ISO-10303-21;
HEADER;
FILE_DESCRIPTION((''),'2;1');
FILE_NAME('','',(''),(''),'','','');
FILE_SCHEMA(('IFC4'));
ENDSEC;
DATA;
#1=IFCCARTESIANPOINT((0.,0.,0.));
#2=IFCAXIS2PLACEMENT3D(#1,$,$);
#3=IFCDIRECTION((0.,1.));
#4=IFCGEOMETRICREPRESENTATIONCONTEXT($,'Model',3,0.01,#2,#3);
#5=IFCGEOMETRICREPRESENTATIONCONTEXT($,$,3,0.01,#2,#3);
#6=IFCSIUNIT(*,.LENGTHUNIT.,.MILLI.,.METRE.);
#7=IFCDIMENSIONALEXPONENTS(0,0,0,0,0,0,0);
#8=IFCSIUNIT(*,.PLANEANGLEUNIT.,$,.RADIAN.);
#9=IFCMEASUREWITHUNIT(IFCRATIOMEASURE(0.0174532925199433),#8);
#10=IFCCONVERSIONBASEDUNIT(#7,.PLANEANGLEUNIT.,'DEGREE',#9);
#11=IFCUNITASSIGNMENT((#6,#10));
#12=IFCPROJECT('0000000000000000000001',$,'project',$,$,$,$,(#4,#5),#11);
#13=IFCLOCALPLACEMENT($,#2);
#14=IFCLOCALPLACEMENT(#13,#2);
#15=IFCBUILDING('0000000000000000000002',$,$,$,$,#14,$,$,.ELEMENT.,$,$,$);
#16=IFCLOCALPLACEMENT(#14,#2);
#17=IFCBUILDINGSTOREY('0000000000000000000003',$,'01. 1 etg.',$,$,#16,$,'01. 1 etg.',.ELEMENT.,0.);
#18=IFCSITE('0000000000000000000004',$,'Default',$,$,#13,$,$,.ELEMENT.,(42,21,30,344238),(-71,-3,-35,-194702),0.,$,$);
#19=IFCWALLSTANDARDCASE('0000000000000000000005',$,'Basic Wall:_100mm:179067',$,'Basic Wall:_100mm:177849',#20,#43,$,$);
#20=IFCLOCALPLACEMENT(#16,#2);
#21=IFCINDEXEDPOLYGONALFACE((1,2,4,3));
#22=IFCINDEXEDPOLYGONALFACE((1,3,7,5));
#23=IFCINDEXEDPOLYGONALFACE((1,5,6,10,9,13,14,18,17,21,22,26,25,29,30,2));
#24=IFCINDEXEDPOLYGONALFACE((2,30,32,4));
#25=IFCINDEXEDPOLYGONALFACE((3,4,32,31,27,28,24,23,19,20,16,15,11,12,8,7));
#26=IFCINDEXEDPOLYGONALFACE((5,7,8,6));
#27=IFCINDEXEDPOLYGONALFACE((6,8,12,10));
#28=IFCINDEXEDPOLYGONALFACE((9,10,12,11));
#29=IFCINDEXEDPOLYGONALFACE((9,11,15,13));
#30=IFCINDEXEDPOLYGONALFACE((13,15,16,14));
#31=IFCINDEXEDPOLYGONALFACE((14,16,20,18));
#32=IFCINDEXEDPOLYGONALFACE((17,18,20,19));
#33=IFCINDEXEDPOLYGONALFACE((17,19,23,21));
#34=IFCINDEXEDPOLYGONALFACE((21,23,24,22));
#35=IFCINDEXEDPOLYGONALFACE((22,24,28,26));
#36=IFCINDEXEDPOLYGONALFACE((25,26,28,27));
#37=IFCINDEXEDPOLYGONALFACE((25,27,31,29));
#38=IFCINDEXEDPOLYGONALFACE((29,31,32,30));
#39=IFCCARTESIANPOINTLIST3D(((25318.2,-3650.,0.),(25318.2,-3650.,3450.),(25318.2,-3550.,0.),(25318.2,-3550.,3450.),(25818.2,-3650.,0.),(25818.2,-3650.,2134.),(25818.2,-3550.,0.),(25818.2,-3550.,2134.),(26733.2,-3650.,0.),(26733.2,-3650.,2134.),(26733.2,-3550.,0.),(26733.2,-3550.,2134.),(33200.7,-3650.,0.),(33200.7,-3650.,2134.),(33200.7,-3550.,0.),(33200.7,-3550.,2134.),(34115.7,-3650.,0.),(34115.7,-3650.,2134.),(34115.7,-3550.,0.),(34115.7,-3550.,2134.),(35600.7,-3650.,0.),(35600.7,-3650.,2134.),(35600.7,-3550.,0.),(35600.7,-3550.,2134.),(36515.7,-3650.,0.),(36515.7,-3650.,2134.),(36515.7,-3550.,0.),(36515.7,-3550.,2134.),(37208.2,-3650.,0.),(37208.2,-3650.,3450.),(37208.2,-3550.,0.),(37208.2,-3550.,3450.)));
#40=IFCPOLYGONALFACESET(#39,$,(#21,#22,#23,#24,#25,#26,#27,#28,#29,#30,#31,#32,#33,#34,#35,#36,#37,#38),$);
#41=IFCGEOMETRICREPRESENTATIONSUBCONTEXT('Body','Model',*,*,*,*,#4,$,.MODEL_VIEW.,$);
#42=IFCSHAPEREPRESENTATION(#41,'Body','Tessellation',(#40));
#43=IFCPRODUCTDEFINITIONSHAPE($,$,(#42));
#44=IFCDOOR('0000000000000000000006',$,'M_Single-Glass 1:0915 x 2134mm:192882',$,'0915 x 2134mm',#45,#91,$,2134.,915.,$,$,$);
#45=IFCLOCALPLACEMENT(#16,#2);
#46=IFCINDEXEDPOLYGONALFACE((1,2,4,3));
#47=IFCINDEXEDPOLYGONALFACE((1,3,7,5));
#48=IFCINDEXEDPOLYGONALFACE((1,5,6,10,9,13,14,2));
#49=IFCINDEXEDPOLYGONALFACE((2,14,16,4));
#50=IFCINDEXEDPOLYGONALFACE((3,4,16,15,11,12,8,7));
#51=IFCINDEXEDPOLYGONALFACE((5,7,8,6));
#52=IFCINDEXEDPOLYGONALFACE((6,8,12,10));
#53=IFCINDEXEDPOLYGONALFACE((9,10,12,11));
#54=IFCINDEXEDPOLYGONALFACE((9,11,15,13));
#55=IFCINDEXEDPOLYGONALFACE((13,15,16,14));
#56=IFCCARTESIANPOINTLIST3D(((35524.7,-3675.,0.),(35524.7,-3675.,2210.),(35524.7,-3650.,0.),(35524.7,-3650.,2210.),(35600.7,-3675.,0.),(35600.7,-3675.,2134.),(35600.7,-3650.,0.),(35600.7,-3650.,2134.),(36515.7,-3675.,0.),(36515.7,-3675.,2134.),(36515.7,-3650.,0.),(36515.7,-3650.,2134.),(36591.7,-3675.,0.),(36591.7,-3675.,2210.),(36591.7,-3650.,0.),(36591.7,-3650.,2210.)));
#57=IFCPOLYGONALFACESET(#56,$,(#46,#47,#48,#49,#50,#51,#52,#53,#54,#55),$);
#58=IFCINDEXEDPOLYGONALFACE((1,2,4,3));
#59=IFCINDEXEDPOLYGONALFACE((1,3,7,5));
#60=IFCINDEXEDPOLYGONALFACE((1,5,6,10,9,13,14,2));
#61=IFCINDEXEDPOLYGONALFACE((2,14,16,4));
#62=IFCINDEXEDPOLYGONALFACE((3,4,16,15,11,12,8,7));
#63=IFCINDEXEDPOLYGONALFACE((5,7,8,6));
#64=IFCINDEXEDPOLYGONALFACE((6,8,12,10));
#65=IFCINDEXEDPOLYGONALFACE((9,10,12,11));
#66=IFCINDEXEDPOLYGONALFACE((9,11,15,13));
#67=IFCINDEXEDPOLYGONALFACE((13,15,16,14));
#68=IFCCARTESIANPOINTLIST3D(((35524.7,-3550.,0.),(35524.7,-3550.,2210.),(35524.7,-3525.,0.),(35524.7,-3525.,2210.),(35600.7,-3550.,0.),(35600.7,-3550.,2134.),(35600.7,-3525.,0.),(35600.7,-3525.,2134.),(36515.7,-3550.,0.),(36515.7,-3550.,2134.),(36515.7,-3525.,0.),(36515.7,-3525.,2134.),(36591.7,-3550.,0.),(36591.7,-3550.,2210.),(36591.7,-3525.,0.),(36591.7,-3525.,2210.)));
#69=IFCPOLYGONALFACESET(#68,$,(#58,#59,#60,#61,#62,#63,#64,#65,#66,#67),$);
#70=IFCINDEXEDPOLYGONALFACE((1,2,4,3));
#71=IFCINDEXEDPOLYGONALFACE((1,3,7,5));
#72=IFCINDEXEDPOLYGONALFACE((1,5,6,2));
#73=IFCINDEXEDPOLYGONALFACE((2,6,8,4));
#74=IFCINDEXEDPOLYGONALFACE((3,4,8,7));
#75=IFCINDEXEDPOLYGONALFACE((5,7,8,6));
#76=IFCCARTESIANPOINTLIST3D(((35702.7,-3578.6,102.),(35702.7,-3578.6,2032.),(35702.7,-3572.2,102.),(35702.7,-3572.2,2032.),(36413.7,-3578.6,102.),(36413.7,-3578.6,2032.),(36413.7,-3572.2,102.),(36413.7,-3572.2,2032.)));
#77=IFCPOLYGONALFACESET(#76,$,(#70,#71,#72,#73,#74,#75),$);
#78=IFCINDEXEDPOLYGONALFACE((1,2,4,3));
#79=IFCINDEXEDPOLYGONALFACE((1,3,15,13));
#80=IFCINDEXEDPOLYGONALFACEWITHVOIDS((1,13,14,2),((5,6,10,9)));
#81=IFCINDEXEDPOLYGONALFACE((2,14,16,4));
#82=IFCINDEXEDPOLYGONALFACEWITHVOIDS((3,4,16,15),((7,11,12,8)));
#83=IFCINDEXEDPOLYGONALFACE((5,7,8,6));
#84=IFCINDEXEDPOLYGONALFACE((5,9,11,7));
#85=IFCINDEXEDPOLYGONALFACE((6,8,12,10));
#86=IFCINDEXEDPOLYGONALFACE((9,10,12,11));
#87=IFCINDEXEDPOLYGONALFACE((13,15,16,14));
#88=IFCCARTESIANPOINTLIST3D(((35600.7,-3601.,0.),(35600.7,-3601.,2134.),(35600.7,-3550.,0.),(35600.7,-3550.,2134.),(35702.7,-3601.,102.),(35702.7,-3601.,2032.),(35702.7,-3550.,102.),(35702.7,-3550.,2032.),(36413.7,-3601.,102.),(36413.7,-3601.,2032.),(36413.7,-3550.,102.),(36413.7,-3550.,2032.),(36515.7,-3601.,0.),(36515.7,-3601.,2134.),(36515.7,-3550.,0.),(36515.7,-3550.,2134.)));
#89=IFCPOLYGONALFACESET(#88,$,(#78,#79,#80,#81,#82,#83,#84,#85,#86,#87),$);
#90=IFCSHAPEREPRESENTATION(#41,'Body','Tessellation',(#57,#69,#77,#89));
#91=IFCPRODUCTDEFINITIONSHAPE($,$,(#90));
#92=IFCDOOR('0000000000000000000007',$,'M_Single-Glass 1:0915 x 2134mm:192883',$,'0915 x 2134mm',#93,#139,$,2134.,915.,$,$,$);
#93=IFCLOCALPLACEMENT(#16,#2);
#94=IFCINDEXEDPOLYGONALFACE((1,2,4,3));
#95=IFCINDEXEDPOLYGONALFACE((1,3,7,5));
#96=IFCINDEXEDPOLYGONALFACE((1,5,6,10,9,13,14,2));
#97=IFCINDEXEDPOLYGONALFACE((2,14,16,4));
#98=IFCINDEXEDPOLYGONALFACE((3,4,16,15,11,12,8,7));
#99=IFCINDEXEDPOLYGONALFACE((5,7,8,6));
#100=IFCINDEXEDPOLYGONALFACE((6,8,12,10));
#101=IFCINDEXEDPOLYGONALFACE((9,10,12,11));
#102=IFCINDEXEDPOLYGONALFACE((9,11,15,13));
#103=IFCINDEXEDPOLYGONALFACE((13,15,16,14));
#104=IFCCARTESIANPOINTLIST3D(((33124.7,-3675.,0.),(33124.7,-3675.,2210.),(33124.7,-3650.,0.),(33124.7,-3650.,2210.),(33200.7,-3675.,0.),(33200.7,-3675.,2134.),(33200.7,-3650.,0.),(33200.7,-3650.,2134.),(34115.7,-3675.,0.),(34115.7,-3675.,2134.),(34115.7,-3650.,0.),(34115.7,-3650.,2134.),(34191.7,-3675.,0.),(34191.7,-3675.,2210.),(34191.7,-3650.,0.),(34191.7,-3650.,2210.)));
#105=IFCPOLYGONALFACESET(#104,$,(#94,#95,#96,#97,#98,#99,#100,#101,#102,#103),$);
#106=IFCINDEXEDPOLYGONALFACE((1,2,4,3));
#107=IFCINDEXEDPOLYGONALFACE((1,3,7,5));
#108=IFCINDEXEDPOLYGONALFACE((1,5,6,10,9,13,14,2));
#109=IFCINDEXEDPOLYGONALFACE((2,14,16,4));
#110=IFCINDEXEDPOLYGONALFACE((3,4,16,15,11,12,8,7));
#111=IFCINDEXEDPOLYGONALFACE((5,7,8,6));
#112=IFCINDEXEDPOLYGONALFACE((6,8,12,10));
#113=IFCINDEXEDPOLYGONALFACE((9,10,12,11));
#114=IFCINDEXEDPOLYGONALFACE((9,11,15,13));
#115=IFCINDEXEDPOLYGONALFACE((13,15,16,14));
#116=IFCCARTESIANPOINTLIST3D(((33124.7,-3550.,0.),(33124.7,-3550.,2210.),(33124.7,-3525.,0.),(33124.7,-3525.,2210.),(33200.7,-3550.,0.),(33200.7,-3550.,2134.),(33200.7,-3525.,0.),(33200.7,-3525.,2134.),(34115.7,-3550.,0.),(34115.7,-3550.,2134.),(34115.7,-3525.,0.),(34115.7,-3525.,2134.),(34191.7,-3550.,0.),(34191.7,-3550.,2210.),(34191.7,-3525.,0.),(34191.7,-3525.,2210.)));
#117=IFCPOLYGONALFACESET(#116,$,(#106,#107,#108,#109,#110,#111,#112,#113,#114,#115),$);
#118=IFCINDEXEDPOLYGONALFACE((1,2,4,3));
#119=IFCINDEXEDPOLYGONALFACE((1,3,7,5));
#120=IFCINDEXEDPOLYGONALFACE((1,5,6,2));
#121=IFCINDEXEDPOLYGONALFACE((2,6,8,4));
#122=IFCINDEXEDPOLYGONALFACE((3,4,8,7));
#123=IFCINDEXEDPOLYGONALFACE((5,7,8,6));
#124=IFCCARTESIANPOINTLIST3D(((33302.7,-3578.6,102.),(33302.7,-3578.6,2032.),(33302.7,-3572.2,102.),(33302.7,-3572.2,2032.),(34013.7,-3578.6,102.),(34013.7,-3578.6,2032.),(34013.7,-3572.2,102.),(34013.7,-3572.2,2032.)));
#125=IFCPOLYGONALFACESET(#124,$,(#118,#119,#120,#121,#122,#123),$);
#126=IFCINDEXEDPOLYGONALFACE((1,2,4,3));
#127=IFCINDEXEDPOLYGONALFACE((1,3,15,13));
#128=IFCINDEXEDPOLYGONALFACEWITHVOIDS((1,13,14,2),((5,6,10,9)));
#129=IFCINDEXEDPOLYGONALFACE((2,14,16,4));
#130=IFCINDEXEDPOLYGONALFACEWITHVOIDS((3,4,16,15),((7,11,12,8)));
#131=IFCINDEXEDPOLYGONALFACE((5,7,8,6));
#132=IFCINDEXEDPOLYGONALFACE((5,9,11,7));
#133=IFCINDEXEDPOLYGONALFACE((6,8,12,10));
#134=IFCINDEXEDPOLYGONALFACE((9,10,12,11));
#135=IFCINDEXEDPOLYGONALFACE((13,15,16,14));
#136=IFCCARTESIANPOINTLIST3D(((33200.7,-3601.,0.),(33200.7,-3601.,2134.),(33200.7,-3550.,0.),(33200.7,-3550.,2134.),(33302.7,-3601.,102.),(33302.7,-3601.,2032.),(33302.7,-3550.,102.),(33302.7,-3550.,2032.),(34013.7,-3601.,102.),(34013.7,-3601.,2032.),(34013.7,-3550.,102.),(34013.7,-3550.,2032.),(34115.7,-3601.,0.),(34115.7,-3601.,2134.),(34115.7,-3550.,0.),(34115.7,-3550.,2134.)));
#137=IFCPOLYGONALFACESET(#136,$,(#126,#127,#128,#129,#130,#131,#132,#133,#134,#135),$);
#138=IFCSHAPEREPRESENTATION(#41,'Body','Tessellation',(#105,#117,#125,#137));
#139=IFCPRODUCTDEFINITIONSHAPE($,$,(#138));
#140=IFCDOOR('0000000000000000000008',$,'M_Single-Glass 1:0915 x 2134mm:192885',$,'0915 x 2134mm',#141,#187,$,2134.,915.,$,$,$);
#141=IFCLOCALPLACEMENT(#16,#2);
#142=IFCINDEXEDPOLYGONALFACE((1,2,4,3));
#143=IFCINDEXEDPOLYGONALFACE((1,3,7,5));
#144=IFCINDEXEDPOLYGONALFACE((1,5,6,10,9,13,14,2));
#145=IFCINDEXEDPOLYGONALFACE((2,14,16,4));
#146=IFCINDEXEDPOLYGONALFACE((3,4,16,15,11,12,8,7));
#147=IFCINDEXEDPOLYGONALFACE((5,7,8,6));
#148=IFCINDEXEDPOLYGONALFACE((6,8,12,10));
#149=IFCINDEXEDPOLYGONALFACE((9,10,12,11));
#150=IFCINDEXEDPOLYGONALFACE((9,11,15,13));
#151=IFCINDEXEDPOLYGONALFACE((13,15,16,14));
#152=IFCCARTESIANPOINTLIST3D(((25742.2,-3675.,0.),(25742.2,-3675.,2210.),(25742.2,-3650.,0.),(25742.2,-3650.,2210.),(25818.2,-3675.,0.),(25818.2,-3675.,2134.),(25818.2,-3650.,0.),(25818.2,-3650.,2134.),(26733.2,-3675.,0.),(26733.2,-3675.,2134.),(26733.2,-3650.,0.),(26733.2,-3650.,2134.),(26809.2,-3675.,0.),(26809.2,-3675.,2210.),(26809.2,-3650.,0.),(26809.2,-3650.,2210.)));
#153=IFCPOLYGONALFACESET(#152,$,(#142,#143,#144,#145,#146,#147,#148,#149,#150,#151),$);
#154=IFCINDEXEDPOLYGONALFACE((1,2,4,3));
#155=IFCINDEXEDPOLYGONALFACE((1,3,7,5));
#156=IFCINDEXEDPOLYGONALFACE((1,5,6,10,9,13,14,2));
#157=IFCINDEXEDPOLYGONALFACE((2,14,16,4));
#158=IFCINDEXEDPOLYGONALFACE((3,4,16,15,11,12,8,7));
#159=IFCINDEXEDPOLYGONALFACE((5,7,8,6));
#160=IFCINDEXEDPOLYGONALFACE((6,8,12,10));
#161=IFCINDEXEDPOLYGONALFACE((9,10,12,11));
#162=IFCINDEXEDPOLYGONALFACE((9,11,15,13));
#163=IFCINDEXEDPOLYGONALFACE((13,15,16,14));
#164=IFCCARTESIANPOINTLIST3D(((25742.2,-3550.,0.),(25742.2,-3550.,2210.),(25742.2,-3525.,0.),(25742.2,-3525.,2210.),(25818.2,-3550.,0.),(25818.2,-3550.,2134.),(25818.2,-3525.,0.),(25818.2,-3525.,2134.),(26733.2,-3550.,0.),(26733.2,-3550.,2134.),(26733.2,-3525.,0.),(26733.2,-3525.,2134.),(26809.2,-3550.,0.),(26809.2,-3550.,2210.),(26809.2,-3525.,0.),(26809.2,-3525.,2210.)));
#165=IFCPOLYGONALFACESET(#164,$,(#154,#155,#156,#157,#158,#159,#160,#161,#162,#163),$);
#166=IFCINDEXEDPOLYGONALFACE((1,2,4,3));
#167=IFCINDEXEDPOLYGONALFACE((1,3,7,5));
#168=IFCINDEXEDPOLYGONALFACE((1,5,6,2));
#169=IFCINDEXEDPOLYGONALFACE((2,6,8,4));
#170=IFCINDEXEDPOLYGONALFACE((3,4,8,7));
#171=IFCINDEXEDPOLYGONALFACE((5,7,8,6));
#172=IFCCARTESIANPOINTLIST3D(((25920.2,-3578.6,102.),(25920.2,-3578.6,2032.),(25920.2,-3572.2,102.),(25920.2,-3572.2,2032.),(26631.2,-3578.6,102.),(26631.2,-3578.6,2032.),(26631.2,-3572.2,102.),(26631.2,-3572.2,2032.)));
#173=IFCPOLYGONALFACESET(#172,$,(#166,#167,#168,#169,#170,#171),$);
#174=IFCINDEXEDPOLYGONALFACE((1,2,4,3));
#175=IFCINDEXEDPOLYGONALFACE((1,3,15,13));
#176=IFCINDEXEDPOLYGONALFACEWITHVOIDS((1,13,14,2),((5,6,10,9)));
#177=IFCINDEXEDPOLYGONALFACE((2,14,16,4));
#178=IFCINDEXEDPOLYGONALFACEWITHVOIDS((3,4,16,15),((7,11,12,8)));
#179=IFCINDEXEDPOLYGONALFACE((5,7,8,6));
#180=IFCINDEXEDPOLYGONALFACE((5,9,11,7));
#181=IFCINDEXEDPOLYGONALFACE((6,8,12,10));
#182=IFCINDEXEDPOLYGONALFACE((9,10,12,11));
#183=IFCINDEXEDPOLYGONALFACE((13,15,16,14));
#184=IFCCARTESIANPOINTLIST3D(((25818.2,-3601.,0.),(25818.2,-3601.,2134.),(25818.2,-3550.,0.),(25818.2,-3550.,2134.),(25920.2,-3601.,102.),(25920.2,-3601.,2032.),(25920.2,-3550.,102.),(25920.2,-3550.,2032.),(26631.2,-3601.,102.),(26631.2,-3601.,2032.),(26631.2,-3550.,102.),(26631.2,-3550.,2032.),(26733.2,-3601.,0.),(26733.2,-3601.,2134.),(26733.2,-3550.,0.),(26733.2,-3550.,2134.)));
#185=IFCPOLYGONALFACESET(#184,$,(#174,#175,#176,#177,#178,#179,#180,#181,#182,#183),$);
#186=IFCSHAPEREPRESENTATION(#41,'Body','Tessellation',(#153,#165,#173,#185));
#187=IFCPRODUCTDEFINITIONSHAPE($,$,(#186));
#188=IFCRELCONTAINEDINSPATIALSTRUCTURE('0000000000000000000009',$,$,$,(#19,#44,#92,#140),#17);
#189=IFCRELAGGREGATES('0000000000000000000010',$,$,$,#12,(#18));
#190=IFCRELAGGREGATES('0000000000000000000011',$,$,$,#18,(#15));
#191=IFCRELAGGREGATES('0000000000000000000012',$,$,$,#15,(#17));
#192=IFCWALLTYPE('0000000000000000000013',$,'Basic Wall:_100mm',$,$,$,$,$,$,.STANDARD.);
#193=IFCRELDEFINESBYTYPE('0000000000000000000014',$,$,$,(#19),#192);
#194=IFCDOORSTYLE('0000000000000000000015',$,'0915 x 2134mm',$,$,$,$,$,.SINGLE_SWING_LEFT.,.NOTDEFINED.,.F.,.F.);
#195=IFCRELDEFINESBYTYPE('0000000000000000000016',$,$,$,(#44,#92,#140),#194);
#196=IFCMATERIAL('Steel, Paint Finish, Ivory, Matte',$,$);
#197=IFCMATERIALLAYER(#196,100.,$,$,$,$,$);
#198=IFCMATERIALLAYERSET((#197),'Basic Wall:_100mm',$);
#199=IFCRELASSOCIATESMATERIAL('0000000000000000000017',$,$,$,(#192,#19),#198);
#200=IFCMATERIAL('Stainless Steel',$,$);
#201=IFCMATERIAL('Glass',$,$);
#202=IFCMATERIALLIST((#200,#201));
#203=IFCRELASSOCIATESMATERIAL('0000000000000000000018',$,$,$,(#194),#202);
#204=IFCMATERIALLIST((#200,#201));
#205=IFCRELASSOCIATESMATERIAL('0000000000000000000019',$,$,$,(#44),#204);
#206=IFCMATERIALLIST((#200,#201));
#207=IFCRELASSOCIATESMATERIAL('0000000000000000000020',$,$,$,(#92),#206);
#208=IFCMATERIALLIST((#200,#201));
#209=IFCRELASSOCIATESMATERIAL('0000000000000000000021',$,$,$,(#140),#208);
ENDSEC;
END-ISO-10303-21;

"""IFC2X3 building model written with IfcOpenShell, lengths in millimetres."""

from ifc_helpers import new_model, entity, si_unit, converted_unit, direction, frame, frame_2d, origin, origin_2d_with_axis, place, context, subcontext, project, spatial, polyline, rectangle, outline, extrude, clip, bounded_halfspace, source, transform, mapped, material, material_list, layer, layer_set, layer_usage, type_object, type_shapes, element, fill, save


model = new_model("IFC2X3")

# Units and contexts
model_context = context("Model", 3, precision=0.01, world=origin(), true_north=direction((0.0, 1.0)))
context_of_model = context(None, 3, precision=0.01, world=origin(), true_north=direction((0.0, 1.0)))
body_context = subcontext(model_context, "Body", "Model", "MODEL_VIEW")
ifc_project = project(units=[si_unit("LENGTHUNIT", "METRE", prefix="MILLI"), converted_unit("PLANEANGLEUNIT", "DEGREE", entity("IfcRatioMeasure", 0.0174532925199433), si_unit("PLANEANGLEUNIT", "RADIAN"), dimensions=[0, 0, 0, 0, 0, 0, 0])], contexts=[model_context, context_of_model])

# Site, building, storey
site_placement = place(None, origin())
site = spatial("IfcSite", under=ifc_project, at=site_placement, Name="Default", CompositionType="ELEMENT", RefLatitude=(42, 21, 30, 344238), RefLongitude=(-71, -3, -35, -194702), RefElevation=0.0)
building_placement = place(site_placement, origin())
building = spatial("IfcBuilding", under=site, at=building_placement, CompositionType="ELEMENT")
storey_placement = place(building_placement, origin())
storey = spatial("IfcBuildingStorey", under=building, at=storey_placement, Name="01. 1 etg.", LongName="01. 1 etg.", CompositionType="ELEMENT", Elevation=0.0)

# Wall, openings, doors
ifc_material_1 = material(Name="Steel, Paint Finish, Ivory, Matte")
ifc_layer_1 = layer(ifc_material_1, 100.0)
ifc_layer_set_1 = layer_set([ifc_layer_1], Name="Basic Wall:_100mm")
ifc_layer_usage_1 = layer_usage(ifc_layer_set_1, "AXIS2", "POSITIVE", -50.0)
wall_type_1 = type_object("IfcWallType", Name="Basic Wall:_100mm", PredefinedType="STANDARD", material=ifc_layer_set_1)
wall_1_placement = place(storey_placement, frame((25318.2, -3600.0, 0.0)))
wall_1 = element("IfcWallStandardCase", 1, at=wall_1_placement, inside=storey, type_object=wall_type_1, material=ifc_layer_usage_1, Name="Basic Wall:_100mm:179067", ObjectType="Basic Wall:_100mm:177849", context=body_context, shape_type="Clipping", body=[
    clip(extrude(rectangle(XDim=11890.0, YDim=100.0, at=frame_2d((5945.0, 0.0), x_axis=(-1.0, 0.0))), origin(), (0.0, 0.0, 1.0), 3450.0), bounded_halfspace(frame((0.0, -50.0, 3450.0), z_axis=(0.0, 0.0, -1.0), x_axis=(0.0, -1.0, 0.0)), True, frame((0.0, -50.0, 3450.0)), polyline([(0.0, 0.0), (11890.0, 0.0), (11890.0, 100.0), (9590.0, 100.0), (9490.0, 100.0), (7190.0, 100.0), (7090.0, 100.0), (0.0, 100.0), (0.0, 0.0)]))),
])
opening_1_placement = place(wall_1_placement, frame((10282.5, -50.0, 0.0)))
opening_1 = element("IfcOpeningElement", 2, at=opening_1_placement, cuts=wall_1, ObjectType="Opening", context=body_context, shape_type="SweptSolid", body=[
    extrude(rectangle(XDim=915.0, YDim=2134.0, at=frame_2d((1067.0, 457.5), x_axis=(0.0, -1.0))), frame((0.0, 0.0, 0.0), z_axis=(0.0, 1.0, 0.0), x_axis=(0.0, 0.0, 1.0)), (0.0, 0.0, 1.0), 100.0),
])
opening_2_placement = place(wall_1_placement, frame((7882.5, -50.0, 0.0)))
opening_2 = element("IfcOpeningElement", 3, at=opening_2_placement, cuts=wall_1, ObjectType="Opening", context=body_context, shape_type="SweptSolid", body=[
    extrude(rectangle(XDim=915.0, YDim=2134.0, at=frame_2d((1067.0, 457.5), x_axis=(0.0, -1.0))), frame((0.0, 0.0, 0.0), z_axis=(0.0, 1.0, 0.0), x_axis=(0.0, 0.0, 1.0)), (0.0, 0.0, 1.0), 100.0),
])
opening_3_placement = place(wall_1_placement, frame((500.0, -50.0, 0.0)))
opening_3 = element("IfcOpeningElement", 4, at=opening_3_placement, cuts=wall_1, ObjectType="Opening", context=body_context, shape_type="SweptSolid", body=[
    extrude(rectangle(XDim=915.0, YDim=2134.0, at=frame_2d((1067.0, 457.5), x_axis=(0.0, -1.0))), frame((0.0, 0.0, 0.0), z_axis=(0.0, 1.0, 0.0), x_axis=(0.0, 0.0, 1.0)), (0.0, 0.0, 1.0), 100.0),
])
ifc_material_2 = material(Name="Stainless Steel")
ifc_material_3 = material(Name="Glass")
ifc_material_list_1 = material_list([ifc_material_2, ifc_material_3])
ifc_material_list_2 = material_list([ifc_material_2, ifc_material_3])
door_style_1 = type_object("IfcDoorStyle", Name="0915 x 2134mm", ConstructionType="NOTDEFINED", OperationType="SINGLE_SWING_LEFT", ParameterTakesPrecedence=False, Sizeable=False, material=ifc_material_list_2)
shared_shape_1 = source(origin(), body_context, "Body", "SweptSolid", [
    extrude(outline(polyline([(-457.5, -1048.0), (-457.5, 1086.0), (-533.5, 1086.0), (-533.5, -1124.0), (533.5, -1124.0), (533.5, 1086.0), (457.5, 1086.0), (457.5, -1048.0), (-457.5, -1048.0)])), frame((457.5, 0.0, 1086.0), z_axis=(0.0, 1.0, 0.0), x_axis=(1.0, 0.0, 0.0)), (0.0, 0.0, -1.0), 25.0),
    extrude(outline(polyline([(-457.5, -1048.0), (-457.5, 1086.0), (-533.5, 1086.0), (-533.5, -1124.0), (533.5, -1124.0), (533.5, 1086.0), (457.5, 1086.0), (457.5, -1048.0), (-457.5, -1048.0)])), frame((457.5, 125.0, 1086.0), z_axis=(0.0, 1.0, 0.0), x_axis=(1.0, 0.0, 0.0)), (0.0, 0.0, -1.0), 25.0),
    extrude(rectangle(XDim=711.0, YDim=6.3, at=origin_2d_with_axis()), frame((457.5, 74.6, 102.0)), (0.0, 0.0, 1.0), 1930.0),
    extrude(outline(polyline([(-1067.0, -457.5), (1067.0, -457.5), (1067.0, 457.5), (-1067.0, 457.5), (-1067.0, -457.5)]), holes=[polyline([(-965.0, 355.5), (965.0, 355.5), (965.0, -355.5), (-965.0, -355.5), (-965.0, 355.5)])]), frame((457.5, 100.0, 1067.0), z_axis=(0.0, -1.0, 0.0), x_axis=(0.0, 0.0, -1.0)), (0.0, 0.0, 1.0), 51.0),
])
type_shapes(door_style_1, [shared_shape_1])
door_1_placement = place(opening_1_placement, origin())
door_1 = element("IfcDoor", 5, at=door_1_placement, inside=storey, type_object=door_style_1, material=ifc_material_list_1, Name="M_Single-Glass 1:0915 x 2134mm:192882", ObjectType="0915 x 2134mm", OverallHeight=2134.0, OverallWidth=915.0, context=body_context, shape_type="MappedRepresentation", body=[
    mapped(shared_shape_1, transform((0.0, 0.0, 0.0), scale=1.0)),
])
fill(opening_1, door_1)
ifc_material_list_3 = material_list([ifc_material_2, ifc_material_3])
door_2_placement = place(opening_2_placement, origin())
door_2 = element("IfcDoor", 6, at=door_2_placement, inside=storey, type_object=door_style_1, material=ifc_material_list_3, Name="M_Single-Glass 1:0915 x 2134mm:192883", ObjectType="0915 x 2134mm", OverallHeight=2134.0, OverallWidth=915.0, context=body_context, shape_type="MappedRepresentation", body=[
    mapped(shared_shape_1, transform((0.0, 0.0, 0.0), scale=1.0)),
])
fill(opening_2, door_2)
ifc_material_list_4 = material_list([ifc_material_2, ifc_material_3])
door_3_placement = place(opening_3_placement, origin())
door_3 = element("IfcDoor", 7, at=door_3_placement, inside=storey, type_object=door_style_1, material=ifc_material_list_4, Name="M_Single-Glass 1:0915 x 2134mm:192885", ObjectType="0915 x 2134mm", OverallHeight=2134.0, OverallWidth=915.0, context=body_context, shape_type="MappedRepresentation", body=[
    mapped(shared_shape_1, transform((0.0, 0.0, 0.0), scale=1.0)),
])
fill(opening_3, door_3)

save(model, "model.ifc")
